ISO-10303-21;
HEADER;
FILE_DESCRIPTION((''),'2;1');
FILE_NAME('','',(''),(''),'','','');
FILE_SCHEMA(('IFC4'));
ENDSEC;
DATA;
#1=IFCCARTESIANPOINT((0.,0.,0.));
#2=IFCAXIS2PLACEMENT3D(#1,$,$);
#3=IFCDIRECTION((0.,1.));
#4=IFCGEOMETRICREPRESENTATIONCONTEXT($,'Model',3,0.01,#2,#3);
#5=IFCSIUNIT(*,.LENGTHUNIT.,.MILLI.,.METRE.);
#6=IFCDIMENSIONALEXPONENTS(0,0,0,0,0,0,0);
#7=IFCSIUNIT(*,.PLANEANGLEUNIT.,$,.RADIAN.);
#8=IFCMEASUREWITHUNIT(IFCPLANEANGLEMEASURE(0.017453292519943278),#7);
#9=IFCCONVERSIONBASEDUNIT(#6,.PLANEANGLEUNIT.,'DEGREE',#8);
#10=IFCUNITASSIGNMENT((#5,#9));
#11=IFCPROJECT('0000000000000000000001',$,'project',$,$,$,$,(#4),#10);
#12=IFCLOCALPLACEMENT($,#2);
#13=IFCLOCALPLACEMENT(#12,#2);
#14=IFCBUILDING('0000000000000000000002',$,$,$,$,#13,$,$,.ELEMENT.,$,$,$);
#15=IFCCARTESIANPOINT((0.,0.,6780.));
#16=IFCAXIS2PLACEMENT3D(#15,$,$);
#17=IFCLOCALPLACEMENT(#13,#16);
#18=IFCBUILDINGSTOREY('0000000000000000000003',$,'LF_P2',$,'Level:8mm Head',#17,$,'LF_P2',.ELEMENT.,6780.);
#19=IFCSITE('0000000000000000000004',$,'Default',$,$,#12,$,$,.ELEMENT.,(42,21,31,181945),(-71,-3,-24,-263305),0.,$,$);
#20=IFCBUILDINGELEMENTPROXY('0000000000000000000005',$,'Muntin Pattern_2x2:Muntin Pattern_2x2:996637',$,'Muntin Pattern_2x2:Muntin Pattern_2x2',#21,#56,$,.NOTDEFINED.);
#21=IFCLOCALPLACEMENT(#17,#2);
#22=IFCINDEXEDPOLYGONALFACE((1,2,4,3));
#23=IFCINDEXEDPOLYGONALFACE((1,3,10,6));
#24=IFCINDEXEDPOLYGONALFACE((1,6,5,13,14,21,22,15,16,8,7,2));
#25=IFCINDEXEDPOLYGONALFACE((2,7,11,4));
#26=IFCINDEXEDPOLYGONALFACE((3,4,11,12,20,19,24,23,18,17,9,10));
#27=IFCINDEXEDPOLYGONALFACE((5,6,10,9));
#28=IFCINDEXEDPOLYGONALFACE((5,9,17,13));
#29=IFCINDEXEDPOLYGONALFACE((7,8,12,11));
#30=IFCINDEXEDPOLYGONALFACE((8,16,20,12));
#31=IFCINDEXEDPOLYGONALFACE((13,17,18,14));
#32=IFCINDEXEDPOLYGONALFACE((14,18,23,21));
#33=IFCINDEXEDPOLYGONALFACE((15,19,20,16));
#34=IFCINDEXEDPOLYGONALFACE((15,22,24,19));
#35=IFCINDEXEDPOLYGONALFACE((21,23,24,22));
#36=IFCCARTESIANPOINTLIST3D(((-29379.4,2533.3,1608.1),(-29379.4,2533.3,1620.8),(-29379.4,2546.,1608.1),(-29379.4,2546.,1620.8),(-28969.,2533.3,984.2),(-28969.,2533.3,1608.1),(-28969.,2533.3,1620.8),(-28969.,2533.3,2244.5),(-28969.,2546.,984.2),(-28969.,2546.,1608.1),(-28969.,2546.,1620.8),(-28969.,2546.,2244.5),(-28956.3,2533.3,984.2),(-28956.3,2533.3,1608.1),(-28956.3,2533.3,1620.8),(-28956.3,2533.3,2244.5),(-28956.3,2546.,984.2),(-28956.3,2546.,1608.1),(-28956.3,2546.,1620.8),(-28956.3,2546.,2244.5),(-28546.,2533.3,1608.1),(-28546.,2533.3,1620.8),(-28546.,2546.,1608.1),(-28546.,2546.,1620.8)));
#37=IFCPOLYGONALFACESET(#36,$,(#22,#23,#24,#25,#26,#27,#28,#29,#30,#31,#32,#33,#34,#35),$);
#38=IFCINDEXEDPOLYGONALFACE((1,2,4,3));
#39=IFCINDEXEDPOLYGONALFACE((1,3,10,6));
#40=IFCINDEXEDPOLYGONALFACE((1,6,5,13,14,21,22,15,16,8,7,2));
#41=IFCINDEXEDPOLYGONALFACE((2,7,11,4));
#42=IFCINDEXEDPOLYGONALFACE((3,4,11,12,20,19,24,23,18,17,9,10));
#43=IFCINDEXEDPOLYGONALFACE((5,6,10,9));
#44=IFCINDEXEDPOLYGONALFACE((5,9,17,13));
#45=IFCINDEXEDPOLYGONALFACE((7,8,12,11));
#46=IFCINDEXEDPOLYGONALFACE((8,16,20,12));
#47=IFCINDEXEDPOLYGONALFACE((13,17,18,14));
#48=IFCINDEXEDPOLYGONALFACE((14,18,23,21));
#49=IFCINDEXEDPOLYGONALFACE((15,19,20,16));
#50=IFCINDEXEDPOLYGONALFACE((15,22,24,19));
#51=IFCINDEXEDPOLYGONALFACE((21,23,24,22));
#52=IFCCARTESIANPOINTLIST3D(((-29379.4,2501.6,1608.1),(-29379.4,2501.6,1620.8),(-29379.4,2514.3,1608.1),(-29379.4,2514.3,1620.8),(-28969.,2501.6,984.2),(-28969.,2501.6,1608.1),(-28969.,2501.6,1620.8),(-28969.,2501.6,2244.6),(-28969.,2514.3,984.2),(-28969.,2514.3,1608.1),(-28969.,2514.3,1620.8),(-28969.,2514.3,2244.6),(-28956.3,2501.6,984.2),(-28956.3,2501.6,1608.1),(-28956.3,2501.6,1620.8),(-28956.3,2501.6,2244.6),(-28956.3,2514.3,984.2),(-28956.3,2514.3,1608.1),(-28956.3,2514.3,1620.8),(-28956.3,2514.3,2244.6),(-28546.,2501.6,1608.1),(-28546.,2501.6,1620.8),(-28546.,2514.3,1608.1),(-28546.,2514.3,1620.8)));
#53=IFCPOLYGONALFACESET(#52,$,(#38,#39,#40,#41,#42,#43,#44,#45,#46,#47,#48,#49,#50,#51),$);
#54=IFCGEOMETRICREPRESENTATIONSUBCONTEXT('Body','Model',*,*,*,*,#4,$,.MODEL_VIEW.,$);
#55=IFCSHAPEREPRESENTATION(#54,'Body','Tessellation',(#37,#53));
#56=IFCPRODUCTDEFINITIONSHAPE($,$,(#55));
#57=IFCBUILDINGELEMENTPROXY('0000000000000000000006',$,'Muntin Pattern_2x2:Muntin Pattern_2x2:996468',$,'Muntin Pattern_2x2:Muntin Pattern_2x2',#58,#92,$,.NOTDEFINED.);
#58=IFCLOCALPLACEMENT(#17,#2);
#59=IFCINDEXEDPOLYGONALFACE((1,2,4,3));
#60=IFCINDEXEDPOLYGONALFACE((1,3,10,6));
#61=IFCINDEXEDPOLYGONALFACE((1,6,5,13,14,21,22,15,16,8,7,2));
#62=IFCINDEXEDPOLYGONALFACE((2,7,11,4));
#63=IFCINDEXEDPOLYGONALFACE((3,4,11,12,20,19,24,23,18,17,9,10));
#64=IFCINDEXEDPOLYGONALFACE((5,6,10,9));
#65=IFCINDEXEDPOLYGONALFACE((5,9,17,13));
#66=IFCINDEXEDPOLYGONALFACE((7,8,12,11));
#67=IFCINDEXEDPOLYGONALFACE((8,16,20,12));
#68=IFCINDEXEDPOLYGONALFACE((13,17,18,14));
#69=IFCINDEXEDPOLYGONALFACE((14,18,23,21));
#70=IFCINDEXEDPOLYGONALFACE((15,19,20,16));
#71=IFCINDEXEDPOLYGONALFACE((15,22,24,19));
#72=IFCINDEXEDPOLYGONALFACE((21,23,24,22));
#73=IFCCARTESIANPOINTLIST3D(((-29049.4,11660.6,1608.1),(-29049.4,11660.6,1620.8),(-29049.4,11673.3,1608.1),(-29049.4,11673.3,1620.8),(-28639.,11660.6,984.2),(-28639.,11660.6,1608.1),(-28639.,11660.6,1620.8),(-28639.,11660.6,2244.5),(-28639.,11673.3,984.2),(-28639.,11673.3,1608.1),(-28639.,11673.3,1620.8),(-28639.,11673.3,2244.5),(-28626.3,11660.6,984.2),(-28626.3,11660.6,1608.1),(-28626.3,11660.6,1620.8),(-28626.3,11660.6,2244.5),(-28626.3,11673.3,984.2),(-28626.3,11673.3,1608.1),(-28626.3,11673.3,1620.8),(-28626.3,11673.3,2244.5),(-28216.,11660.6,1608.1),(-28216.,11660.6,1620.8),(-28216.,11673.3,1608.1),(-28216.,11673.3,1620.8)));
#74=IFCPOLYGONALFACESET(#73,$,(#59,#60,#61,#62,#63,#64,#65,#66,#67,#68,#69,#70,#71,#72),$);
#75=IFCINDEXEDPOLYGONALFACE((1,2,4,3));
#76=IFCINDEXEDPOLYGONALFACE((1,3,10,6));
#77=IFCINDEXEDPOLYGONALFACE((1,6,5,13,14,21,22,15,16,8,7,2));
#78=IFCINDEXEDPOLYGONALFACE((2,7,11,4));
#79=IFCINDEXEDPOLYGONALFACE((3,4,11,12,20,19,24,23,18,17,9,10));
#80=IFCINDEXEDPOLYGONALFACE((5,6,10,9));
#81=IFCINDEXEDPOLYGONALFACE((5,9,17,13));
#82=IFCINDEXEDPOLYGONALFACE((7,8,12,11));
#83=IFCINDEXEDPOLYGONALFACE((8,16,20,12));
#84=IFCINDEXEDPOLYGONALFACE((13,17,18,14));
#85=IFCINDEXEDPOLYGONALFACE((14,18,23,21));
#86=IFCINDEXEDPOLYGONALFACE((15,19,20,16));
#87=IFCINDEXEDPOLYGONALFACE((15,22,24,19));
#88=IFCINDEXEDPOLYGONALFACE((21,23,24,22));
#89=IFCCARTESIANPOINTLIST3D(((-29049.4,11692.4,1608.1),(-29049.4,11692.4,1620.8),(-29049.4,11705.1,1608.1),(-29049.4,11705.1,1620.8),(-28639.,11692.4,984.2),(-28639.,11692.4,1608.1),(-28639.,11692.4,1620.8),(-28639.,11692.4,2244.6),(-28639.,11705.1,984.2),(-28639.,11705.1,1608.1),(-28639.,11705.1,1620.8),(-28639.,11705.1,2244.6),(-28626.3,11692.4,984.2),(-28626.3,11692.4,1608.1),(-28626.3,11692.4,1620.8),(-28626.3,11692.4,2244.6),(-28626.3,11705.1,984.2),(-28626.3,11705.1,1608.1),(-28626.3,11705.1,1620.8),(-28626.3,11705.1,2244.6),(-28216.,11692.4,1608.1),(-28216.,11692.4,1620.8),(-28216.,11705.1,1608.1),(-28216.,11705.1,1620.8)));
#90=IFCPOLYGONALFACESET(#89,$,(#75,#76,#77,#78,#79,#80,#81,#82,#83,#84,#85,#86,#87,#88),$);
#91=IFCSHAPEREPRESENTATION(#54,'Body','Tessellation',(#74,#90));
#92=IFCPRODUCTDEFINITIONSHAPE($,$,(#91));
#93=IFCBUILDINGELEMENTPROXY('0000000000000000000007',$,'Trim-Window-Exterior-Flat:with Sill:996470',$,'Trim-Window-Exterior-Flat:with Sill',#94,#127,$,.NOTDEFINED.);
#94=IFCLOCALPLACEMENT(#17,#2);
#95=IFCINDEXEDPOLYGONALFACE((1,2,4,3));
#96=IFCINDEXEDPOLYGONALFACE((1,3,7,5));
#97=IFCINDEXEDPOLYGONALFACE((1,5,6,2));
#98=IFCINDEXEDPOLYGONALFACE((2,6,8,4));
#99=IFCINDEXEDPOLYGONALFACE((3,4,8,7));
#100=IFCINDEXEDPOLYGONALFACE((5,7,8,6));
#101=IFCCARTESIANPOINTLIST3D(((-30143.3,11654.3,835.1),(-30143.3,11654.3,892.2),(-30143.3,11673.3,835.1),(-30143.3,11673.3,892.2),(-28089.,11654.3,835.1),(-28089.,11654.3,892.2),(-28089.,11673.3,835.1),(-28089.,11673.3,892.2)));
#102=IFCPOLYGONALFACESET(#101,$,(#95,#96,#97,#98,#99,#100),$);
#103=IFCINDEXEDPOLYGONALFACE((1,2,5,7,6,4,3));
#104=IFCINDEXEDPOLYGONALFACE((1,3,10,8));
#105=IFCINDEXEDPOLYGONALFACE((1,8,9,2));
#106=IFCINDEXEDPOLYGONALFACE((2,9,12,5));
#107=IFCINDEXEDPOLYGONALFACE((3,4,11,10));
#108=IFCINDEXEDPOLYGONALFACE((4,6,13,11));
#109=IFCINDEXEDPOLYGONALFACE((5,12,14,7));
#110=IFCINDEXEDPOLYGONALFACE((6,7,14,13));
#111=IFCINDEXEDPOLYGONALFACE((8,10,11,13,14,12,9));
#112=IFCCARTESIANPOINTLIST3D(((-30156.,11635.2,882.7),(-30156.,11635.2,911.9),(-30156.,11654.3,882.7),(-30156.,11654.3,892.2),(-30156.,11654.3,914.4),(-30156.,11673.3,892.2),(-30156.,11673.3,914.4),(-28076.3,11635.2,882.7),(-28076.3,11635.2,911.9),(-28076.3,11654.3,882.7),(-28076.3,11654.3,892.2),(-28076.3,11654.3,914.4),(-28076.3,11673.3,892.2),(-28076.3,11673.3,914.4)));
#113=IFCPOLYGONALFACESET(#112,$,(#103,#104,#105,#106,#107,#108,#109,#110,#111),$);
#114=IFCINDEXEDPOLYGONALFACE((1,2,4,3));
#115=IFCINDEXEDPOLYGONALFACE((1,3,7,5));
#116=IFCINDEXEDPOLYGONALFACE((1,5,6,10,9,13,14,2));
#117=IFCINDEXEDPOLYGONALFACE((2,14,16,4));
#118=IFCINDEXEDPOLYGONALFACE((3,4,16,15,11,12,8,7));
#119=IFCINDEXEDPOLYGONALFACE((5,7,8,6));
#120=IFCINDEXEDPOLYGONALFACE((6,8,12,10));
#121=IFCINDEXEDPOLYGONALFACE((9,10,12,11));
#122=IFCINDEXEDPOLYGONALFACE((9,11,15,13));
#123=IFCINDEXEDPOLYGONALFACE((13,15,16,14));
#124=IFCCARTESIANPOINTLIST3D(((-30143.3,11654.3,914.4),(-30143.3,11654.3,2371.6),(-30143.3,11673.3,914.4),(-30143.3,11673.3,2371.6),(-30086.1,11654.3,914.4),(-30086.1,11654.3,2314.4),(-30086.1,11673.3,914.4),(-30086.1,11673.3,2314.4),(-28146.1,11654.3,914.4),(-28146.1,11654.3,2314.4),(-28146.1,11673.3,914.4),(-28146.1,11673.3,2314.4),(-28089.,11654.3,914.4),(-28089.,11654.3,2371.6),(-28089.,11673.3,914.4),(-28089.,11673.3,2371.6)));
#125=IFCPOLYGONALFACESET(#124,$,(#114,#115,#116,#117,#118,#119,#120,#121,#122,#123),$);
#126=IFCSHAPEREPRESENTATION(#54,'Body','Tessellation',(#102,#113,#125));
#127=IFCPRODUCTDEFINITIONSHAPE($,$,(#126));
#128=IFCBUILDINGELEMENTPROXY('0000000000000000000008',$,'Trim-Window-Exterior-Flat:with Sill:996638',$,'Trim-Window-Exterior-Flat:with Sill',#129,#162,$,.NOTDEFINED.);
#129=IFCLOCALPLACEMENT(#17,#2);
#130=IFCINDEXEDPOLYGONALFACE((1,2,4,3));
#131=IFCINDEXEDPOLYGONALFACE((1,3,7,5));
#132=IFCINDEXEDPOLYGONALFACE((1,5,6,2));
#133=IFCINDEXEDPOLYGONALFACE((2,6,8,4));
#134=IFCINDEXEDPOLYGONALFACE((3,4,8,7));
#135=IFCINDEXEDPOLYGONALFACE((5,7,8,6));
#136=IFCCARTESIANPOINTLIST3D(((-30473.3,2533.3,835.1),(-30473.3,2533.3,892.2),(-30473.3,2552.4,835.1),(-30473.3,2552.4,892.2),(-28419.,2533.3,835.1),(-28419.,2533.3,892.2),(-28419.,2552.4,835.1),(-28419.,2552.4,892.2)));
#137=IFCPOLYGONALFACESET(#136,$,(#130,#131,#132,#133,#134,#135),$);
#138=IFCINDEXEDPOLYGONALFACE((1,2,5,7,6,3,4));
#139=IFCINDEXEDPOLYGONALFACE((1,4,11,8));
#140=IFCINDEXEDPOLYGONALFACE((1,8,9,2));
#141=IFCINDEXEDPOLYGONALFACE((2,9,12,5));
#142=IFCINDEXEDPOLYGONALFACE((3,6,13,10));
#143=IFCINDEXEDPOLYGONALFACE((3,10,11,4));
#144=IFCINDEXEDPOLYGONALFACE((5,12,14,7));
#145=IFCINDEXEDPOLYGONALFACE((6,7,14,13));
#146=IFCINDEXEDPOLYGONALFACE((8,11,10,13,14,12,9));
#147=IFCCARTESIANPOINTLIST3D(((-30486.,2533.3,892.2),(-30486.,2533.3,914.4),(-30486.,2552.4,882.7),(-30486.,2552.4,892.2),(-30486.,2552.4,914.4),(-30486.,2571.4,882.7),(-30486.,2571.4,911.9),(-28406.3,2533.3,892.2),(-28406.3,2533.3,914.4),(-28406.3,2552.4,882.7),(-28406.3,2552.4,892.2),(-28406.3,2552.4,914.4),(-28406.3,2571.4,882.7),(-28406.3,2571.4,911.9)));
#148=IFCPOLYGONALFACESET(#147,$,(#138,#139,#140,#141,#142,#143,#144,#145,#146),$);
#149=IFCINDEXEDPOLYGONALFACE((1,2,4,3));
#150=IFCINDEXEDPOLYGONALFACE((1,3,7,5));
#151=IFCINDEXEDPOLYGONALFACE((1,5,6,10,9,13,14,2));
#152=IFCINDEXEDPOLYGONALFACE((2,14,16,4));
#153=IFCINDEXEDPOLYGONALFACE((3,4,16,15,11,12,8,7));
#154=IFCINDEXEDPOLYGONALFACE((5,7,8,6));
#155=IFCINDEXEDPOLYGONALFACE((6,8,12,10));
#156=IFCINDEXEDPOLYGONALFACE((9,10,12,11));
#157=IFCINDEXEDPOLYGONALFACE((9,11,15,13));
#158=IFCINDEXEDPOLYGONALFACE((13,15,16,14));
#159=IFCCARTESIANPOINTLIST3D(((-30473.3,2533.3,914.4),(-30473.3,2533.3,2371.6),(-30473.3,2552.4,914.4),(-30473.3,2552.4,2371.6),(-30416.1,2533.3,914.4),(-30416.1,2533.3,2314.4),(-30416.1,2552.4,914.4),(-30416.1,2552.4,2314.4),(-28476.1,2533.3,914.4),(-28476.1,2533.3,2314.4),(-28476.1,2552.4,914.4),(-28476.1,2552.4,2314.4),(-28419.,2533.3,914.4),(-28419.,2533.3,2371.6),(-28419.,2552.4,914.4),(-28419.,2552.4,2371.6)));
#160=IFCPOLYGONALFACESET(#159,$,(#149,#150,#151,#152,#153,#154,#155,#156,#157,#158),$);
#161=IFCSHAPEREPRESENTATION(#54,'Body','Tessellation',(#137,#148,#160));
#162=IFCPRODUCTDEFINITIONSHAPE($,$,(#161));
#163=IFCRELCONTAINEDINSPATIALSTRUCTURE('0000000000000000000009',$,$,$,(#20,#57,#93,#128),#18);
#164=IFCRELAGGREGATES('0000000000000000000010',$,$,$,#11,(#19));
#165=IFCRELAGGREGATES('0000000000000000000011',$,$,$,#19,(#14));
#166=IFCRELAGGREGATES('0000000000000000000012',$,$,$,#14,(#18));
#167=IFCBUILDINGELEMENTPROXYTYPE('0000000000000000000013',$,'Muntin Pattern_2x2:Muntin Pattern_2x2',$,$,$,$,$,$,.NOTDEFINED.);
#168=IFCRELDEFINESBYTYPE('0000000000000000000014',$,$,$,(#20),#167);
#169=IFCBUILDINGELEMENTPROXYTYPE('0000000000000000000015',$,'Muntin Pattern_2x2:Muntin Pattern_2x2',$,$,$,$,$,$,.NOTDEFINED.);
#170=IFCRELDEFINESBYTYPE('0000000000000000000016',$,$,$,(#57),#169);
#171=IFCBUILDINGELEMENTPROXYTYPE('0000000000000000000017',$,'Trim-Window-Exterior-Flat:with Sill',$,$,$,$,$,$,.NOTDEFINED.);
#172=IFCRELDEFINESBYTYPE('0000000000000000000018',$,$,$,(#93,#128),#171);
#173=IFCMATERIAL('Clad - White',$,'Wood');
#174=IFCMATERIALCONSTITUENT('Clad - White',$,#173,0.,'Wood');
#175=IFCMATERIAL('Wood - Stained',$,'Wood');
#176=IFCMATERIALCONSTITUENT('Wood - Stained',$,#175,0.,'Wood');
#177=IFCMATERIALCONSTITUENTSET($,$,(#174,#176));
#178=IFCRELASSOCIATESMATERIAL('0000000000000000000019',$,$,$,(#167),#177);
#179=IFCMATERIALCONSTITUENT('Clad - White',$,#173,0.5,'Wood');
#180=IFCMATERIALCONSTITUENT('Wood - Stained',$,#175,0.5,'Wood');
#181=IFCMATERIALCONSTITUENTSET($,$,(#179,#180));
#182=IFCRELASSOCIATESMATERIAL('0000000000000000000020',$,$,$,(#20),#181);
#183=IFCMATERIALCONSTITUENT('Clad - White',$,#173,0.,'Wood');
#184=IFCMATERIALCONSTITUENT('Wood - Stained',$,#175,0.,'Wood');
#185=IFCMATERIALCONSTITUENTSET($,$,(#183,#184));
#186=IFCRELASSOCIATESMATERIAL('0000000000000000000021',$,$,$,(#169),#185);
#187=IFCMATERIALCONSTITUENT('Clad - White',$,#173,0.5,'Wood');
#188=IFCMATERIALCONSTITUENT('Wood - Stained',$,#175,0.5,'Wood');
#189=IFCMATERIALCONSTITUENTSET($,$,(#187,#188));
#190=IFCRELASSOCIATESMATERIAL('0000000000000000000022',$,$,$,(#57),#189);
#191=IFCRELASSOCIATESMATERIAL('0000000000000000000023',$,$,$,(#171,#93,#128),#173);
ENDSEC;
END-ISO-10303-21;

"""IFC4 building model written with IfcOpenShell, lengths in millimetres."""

from ifc_helpers import new_model, entity, si_unit, converted_unit, direction, frame, origin, place, context, subcontext, project, spatial, indexed_curve, outline, extrude, source, transform, mapped, material, constituent, constituent_set, type_object, type_shapes, element, save


model = new_model("IFC4")

# Units and contexts
model_context = context("Model", 3, precision=0.01, world=origin(), true_north=direction((0.0, 1.0)))
body_context = subcontext(model_context, "Body", "Model", "MODEL_VIEW")
ifc_project = project(units=[si_unit("LENGTHUNIT", "METRE", prefix="MILLI"), converted_unit("PLANEANGLEUNIT", "DEGREE", entity("IfcPlaneAngleMeasure", 0.017453292519943278), si_unit("PLANEANGLEUNIT", "RADIAN"), dimensions=[0, 0, 0, 0, 0, 0, 0])], contexts=[model_context])

# Site, building, storey
site_placement = place(None, origin())
site = spatial("IfcSite", under=ifc_project, at=site_placement, Name="Default", CompositionType="ELEMENT", RefLatitude=(42, 21, 31, 181945), RefLongitude=(-71, -3, -24, -263305), RefElevation=0.0)
building_placement = place(site_placement, origin())
building = spatial("IfcBuilding", under=site, at=building_placement, CompositionType="ELEMENT")
storey_placement = place(building_placement, frame((0.0, 0.0, 6780.0)))
storey = spatial("IfcBuildingStorey", under=building, at=storey_placement, Name="LF_P2", ObjectType="Level:8mm Head", LongName="LF_P2", CompositionType="ELEMENT", Elevation=6780.0)

# Building element proxies
ifc_material_1 = material(Name="Clad - White", Category="Wood")
ifc_material_2 = material(Name="Wood - Stained", Category="Wood")
ifc_constituent_1 = constituent(ifc_material_1, Name="Clad - White", Category="Wood", fraction=0.0)
ifc_constituent_2 = constituent(ifc_material_2, Name="Wood - Stained", Category="Wood", fraction=0.0)
ifc_constituent_set_1 = constituent_set(constituents=[ifc_constituent_1, ifc_constituent_2])
building_element_proxy_type_1 = type_object("IfcBuildingElementProxyType", Name="Muntin Pattern_2x2:Muntin Pattern_2x2", PredefinedType="NOTDEFINED", material=ifc_constituent_set_1)
shared_shape_1 = source(origin(), body_context, "Body", "SweptSolid", [
    extrude(outline(indexed_curve([(6.4, -6.4), (630.1, -6.4), (630.1, 6.3), (6.4, 6.3), (6.4, 416.7), (-6.3, 416.7), (-6.3, 6.3), (-630.2, 6.3), (-630.2, -6.4), (-6.3, -6.4), (-6.3, -416.7), (6.4, -416.7), (6.4, -6.4)], self_intersect=False)), frame((0.0, -22.2, 630.1), z_axis=(0.0, 1.0, 0.0), x_axis=(0.0, 0.0, 1.0)), (0.0, 0.0, 1.0), 12.7),
    extrude(outline(indexed_curve([(6.4, -6.4), (630.2, -6.4), (630.2, 6.3), (6.4, 6.3), (6.4, 416.7), (-6.3, 416.7), (-6.3, 6.3), (-630.2, 6.3), (-630.2, -6.4), (-6.3, -6.4), (-6.3, -416.7), (6.4, -416.7), (6.4, -6.4)], self_intersect=False)), frame((0.0, 9.5, 630.2), z_axis=(0.0, 1.0, 0.0), x_axis=(0.0, 0.0, 1.0)), (0.0, 0.0, 1.0), 12.7),
])
type_shapes(building_element_proxy_type_1, [shared_shape_1])
ifc_constituent_3 = constituent(ifc_material_1, Name="Clad - White", Category="Wood", fraction=0.5)
ifc_constituent_4 = constituent(ifc_material_2, Name="Wood - Stained", Category="Wood", fraction=0.5)
ifc_constituent_set_2 = constituent_set(constituents=[ifc_constituent_3, ifc_constituent_4])
proxy_1_placement = place(storey_placement, frame((-28962.7, 2523.8, 984.3), z_axis=(0.0, 0.0, 1.0), x_axis=(-1.0, 0.0, 0.0)))
element("IfcBuildingElementProxy", 1, at=proxy_1_placement, inside=storey, type_object=building_element_proxy_type_1, material=ifc_constituent_set_2, Name="Muntin Pattern_2x2:Muntin Pattern_2x2:996637", ObjectType="Muntin Pattern_2x2:Muntin Pattern_2x2", PredefinedType="NOTDEFINED", context=body_context, shape_type="MappedRepresentation", body=[
    mapped(shared_shape_1, transform((0.0, 0.0, 0.0), scale=1.0)),
])
ifc_constituent_5 = constituent(ifc_material_1, Name="Clad - White", Category="Wood", fraction=0.5)
ifc_constituent_6 = constituent(ifc_material_2, Name="Wood - Stained", Category="Wood", fraction=0.5)
ifc_constituent_set_3 = constituent_set(constituents=[ifc_constituent_5, ifc_constituent_6])
ifc_constituent_7 = constituent(ifc_material_1, Name="Clad - White", Category="Wood", fraction=0.0)
ifc_constituent_8 = constituent(ifc_material_2, Name="Wood - Stained", Category="Wood", fraction=0.0)
ifc_constituent_set_4 = constituent_set(constituents=[ifc_constituent_7, ifc_constituent_8])
building_element_proxy_type_2 = type_object("IfcBuildingElementProxyType", Name="Muntin Pattern_2x2:Muntin Pattern_2x2", PredefinedType="NOTDEFINED", material=ifc_constituent_set_4)
shared_shape_2 = source(origin(), body_context, "Body", "SweptSolid", [
    extrude(outline(indexed_curve([(6.4, -6.4), (630.1, -6.4), (630.1, 6.3), (6.4, 6.3), (6.4, 416.7), (-6.3, 416.7), (-6.3, 6.3), (-630.2, 6.3), (-630.2, -6.4), (-6.3, -6.4), (-6.3, -416.7), (6.4, -416.7), (6.4, -6.4)], self_intersect=False)), frame((0.0, 9.5, 630.1), z_axis=(0.0, 1.0, 0.0), x_axis=(0.0, 0.0, 1.0)), (0.0, 0.0, 1.0), 12.7),
    extrude(outline(indexed_curve([(6.4, -6.4), (630.2, -6.4), (630.2, 6.3), (6.4, 6.3), (6.4, 416.7), (-6.3, 416.7), (-6.3, 6.3), (-630.2, 6.3), (-630.2, -6.4), (-6.3, -6.4), (-6.3, -416.7), (6.4, -416.7), (6.4, -6.4)], self_intersect=False)), frame((0.0, -22.2, 630.2), z_axis=(0.0, 1.0, 0.0), x_axis=(0.0, 0.0, 1.0)), (0.0, 0.0, 1.0), 12.7),
])
type_shapes(building_element_proxy_type_2, [shared_shape_2])
proxy_2_placement = place(storey_placement, frame((-28632.7, 11682.9, 984.3), z_axis=(0.0, 0.0, 1.0), x_axis=(-1.0, 0.0, 0.0)))
element("IfcBuildingElementProxy", 2, at=proxy_2_placement, inside=storey, type_object=building_element_proxy_type_2, material=ifc_constituent_set_3, Name="Muntin Pattern_2x2:Muntin Pattern_2x2:996468", ObjectType="Muntin Pattern_2x2:Muntin Pattern_2x2", PredefinedType="NOTDEFINED", context=body_context, shape_type="MappedRepresentation", body=[
    mapped(shared_shape_2, transform((0.0, 0.0, 0.0), scale=1.0)),
])
building_element_proxy_type_3 = type_object("IfcBuildingElementProxyType", Name="Trim-Window-Exterior-Flat:with Sill", PredefinedType="NOTDEFINED", material=ifc_material_1)
shared_shape_3 = source(origin(), body_context, "Body", "SweptSolid", [
    extrude(outline(indexed_curve([(-1027.1, -28.6), (1027.1, -28.6), (1027.1, 28.6), (-1027.1, 28.6), (-1027.1, -28.6)], self_intersect=False)), frame((0.0, -1450.8, 0.0), z_axis=(0.0, 0.0, 1.0), x_axis=(-1.0, 0.0, 0.0)), (0.0, 0.0, 1.0), 19.0),
    extrude(outline(indexed_curve([(-19.0, -16.0), (0.0, -16.0), (0.0, -6.4), (19.0, -6.4), (19.0, 15.8), (0.0, 15.8), (-19.0, 13.3), (-19.0, -16.0)], self_intersect=False)), frame((-1039.8, -1415.8, 19.0), z_axis=(1.0, 0.0, 0.0), x_axis=(0.0, 0.0, -1.0)), (0.0, 0.0, 1.0), 2079.7),
    extrude(outline(indexed_curve([(-742.9, -1027.1), (714.3, -1027.1), (714.3, -970.0), (-685.7, -970.0), (-685.7, 970.0), (714.3, 970.0), (714.3, 1027.1), (-742.9, 1027.1), (-742.9, -1027.1)], self_intersect=False)), frame((0.0, -685.7, 0.0), z_axis=(0.0, 0.0, 1.0), x_axis=(0.0, -1.0, 0.0)), (0.0, 0.0, 1.0), 19.0),
])
type_shapes(building_element_proxy_type_3, [shared_shape_3])
for number, where, z_axis, x_axis, name in (
    (3, (-29116.1, 11673.3, 2314.4), (0.0, -1.0, 0.0), (1.0, 0.0, 0.0), "Trim-Window-Exterior-Flat:with Sill:996470"),
    (4, (-29446.1, 2533.3, 2314.4), (0.0, 1.0, 0.0), (-1.0, 0.0, 0.0), "Trim-Window-Exterior-Flat:with Sill:996638"),
):
    element("IfcBuildingElementProxy", number, at=place(storey_placement, frame(where, z_axis=z_axis, x_axis=x_axis)), inside=storey, type_object=building_element_proxy_type_3, material=ifc_material_1, Name=name, ObjectType="Trim-Window-Exterior-Flat:with Sill", PredefinedType="NOTDEFINED", context=body_context, shape_type="MappedRepresentation", body=[
        mapped(shared_shape_3, transform((0.0, 0.0, 0.0), scale=1.0)),
    ])

save(model, "model.ifc")
